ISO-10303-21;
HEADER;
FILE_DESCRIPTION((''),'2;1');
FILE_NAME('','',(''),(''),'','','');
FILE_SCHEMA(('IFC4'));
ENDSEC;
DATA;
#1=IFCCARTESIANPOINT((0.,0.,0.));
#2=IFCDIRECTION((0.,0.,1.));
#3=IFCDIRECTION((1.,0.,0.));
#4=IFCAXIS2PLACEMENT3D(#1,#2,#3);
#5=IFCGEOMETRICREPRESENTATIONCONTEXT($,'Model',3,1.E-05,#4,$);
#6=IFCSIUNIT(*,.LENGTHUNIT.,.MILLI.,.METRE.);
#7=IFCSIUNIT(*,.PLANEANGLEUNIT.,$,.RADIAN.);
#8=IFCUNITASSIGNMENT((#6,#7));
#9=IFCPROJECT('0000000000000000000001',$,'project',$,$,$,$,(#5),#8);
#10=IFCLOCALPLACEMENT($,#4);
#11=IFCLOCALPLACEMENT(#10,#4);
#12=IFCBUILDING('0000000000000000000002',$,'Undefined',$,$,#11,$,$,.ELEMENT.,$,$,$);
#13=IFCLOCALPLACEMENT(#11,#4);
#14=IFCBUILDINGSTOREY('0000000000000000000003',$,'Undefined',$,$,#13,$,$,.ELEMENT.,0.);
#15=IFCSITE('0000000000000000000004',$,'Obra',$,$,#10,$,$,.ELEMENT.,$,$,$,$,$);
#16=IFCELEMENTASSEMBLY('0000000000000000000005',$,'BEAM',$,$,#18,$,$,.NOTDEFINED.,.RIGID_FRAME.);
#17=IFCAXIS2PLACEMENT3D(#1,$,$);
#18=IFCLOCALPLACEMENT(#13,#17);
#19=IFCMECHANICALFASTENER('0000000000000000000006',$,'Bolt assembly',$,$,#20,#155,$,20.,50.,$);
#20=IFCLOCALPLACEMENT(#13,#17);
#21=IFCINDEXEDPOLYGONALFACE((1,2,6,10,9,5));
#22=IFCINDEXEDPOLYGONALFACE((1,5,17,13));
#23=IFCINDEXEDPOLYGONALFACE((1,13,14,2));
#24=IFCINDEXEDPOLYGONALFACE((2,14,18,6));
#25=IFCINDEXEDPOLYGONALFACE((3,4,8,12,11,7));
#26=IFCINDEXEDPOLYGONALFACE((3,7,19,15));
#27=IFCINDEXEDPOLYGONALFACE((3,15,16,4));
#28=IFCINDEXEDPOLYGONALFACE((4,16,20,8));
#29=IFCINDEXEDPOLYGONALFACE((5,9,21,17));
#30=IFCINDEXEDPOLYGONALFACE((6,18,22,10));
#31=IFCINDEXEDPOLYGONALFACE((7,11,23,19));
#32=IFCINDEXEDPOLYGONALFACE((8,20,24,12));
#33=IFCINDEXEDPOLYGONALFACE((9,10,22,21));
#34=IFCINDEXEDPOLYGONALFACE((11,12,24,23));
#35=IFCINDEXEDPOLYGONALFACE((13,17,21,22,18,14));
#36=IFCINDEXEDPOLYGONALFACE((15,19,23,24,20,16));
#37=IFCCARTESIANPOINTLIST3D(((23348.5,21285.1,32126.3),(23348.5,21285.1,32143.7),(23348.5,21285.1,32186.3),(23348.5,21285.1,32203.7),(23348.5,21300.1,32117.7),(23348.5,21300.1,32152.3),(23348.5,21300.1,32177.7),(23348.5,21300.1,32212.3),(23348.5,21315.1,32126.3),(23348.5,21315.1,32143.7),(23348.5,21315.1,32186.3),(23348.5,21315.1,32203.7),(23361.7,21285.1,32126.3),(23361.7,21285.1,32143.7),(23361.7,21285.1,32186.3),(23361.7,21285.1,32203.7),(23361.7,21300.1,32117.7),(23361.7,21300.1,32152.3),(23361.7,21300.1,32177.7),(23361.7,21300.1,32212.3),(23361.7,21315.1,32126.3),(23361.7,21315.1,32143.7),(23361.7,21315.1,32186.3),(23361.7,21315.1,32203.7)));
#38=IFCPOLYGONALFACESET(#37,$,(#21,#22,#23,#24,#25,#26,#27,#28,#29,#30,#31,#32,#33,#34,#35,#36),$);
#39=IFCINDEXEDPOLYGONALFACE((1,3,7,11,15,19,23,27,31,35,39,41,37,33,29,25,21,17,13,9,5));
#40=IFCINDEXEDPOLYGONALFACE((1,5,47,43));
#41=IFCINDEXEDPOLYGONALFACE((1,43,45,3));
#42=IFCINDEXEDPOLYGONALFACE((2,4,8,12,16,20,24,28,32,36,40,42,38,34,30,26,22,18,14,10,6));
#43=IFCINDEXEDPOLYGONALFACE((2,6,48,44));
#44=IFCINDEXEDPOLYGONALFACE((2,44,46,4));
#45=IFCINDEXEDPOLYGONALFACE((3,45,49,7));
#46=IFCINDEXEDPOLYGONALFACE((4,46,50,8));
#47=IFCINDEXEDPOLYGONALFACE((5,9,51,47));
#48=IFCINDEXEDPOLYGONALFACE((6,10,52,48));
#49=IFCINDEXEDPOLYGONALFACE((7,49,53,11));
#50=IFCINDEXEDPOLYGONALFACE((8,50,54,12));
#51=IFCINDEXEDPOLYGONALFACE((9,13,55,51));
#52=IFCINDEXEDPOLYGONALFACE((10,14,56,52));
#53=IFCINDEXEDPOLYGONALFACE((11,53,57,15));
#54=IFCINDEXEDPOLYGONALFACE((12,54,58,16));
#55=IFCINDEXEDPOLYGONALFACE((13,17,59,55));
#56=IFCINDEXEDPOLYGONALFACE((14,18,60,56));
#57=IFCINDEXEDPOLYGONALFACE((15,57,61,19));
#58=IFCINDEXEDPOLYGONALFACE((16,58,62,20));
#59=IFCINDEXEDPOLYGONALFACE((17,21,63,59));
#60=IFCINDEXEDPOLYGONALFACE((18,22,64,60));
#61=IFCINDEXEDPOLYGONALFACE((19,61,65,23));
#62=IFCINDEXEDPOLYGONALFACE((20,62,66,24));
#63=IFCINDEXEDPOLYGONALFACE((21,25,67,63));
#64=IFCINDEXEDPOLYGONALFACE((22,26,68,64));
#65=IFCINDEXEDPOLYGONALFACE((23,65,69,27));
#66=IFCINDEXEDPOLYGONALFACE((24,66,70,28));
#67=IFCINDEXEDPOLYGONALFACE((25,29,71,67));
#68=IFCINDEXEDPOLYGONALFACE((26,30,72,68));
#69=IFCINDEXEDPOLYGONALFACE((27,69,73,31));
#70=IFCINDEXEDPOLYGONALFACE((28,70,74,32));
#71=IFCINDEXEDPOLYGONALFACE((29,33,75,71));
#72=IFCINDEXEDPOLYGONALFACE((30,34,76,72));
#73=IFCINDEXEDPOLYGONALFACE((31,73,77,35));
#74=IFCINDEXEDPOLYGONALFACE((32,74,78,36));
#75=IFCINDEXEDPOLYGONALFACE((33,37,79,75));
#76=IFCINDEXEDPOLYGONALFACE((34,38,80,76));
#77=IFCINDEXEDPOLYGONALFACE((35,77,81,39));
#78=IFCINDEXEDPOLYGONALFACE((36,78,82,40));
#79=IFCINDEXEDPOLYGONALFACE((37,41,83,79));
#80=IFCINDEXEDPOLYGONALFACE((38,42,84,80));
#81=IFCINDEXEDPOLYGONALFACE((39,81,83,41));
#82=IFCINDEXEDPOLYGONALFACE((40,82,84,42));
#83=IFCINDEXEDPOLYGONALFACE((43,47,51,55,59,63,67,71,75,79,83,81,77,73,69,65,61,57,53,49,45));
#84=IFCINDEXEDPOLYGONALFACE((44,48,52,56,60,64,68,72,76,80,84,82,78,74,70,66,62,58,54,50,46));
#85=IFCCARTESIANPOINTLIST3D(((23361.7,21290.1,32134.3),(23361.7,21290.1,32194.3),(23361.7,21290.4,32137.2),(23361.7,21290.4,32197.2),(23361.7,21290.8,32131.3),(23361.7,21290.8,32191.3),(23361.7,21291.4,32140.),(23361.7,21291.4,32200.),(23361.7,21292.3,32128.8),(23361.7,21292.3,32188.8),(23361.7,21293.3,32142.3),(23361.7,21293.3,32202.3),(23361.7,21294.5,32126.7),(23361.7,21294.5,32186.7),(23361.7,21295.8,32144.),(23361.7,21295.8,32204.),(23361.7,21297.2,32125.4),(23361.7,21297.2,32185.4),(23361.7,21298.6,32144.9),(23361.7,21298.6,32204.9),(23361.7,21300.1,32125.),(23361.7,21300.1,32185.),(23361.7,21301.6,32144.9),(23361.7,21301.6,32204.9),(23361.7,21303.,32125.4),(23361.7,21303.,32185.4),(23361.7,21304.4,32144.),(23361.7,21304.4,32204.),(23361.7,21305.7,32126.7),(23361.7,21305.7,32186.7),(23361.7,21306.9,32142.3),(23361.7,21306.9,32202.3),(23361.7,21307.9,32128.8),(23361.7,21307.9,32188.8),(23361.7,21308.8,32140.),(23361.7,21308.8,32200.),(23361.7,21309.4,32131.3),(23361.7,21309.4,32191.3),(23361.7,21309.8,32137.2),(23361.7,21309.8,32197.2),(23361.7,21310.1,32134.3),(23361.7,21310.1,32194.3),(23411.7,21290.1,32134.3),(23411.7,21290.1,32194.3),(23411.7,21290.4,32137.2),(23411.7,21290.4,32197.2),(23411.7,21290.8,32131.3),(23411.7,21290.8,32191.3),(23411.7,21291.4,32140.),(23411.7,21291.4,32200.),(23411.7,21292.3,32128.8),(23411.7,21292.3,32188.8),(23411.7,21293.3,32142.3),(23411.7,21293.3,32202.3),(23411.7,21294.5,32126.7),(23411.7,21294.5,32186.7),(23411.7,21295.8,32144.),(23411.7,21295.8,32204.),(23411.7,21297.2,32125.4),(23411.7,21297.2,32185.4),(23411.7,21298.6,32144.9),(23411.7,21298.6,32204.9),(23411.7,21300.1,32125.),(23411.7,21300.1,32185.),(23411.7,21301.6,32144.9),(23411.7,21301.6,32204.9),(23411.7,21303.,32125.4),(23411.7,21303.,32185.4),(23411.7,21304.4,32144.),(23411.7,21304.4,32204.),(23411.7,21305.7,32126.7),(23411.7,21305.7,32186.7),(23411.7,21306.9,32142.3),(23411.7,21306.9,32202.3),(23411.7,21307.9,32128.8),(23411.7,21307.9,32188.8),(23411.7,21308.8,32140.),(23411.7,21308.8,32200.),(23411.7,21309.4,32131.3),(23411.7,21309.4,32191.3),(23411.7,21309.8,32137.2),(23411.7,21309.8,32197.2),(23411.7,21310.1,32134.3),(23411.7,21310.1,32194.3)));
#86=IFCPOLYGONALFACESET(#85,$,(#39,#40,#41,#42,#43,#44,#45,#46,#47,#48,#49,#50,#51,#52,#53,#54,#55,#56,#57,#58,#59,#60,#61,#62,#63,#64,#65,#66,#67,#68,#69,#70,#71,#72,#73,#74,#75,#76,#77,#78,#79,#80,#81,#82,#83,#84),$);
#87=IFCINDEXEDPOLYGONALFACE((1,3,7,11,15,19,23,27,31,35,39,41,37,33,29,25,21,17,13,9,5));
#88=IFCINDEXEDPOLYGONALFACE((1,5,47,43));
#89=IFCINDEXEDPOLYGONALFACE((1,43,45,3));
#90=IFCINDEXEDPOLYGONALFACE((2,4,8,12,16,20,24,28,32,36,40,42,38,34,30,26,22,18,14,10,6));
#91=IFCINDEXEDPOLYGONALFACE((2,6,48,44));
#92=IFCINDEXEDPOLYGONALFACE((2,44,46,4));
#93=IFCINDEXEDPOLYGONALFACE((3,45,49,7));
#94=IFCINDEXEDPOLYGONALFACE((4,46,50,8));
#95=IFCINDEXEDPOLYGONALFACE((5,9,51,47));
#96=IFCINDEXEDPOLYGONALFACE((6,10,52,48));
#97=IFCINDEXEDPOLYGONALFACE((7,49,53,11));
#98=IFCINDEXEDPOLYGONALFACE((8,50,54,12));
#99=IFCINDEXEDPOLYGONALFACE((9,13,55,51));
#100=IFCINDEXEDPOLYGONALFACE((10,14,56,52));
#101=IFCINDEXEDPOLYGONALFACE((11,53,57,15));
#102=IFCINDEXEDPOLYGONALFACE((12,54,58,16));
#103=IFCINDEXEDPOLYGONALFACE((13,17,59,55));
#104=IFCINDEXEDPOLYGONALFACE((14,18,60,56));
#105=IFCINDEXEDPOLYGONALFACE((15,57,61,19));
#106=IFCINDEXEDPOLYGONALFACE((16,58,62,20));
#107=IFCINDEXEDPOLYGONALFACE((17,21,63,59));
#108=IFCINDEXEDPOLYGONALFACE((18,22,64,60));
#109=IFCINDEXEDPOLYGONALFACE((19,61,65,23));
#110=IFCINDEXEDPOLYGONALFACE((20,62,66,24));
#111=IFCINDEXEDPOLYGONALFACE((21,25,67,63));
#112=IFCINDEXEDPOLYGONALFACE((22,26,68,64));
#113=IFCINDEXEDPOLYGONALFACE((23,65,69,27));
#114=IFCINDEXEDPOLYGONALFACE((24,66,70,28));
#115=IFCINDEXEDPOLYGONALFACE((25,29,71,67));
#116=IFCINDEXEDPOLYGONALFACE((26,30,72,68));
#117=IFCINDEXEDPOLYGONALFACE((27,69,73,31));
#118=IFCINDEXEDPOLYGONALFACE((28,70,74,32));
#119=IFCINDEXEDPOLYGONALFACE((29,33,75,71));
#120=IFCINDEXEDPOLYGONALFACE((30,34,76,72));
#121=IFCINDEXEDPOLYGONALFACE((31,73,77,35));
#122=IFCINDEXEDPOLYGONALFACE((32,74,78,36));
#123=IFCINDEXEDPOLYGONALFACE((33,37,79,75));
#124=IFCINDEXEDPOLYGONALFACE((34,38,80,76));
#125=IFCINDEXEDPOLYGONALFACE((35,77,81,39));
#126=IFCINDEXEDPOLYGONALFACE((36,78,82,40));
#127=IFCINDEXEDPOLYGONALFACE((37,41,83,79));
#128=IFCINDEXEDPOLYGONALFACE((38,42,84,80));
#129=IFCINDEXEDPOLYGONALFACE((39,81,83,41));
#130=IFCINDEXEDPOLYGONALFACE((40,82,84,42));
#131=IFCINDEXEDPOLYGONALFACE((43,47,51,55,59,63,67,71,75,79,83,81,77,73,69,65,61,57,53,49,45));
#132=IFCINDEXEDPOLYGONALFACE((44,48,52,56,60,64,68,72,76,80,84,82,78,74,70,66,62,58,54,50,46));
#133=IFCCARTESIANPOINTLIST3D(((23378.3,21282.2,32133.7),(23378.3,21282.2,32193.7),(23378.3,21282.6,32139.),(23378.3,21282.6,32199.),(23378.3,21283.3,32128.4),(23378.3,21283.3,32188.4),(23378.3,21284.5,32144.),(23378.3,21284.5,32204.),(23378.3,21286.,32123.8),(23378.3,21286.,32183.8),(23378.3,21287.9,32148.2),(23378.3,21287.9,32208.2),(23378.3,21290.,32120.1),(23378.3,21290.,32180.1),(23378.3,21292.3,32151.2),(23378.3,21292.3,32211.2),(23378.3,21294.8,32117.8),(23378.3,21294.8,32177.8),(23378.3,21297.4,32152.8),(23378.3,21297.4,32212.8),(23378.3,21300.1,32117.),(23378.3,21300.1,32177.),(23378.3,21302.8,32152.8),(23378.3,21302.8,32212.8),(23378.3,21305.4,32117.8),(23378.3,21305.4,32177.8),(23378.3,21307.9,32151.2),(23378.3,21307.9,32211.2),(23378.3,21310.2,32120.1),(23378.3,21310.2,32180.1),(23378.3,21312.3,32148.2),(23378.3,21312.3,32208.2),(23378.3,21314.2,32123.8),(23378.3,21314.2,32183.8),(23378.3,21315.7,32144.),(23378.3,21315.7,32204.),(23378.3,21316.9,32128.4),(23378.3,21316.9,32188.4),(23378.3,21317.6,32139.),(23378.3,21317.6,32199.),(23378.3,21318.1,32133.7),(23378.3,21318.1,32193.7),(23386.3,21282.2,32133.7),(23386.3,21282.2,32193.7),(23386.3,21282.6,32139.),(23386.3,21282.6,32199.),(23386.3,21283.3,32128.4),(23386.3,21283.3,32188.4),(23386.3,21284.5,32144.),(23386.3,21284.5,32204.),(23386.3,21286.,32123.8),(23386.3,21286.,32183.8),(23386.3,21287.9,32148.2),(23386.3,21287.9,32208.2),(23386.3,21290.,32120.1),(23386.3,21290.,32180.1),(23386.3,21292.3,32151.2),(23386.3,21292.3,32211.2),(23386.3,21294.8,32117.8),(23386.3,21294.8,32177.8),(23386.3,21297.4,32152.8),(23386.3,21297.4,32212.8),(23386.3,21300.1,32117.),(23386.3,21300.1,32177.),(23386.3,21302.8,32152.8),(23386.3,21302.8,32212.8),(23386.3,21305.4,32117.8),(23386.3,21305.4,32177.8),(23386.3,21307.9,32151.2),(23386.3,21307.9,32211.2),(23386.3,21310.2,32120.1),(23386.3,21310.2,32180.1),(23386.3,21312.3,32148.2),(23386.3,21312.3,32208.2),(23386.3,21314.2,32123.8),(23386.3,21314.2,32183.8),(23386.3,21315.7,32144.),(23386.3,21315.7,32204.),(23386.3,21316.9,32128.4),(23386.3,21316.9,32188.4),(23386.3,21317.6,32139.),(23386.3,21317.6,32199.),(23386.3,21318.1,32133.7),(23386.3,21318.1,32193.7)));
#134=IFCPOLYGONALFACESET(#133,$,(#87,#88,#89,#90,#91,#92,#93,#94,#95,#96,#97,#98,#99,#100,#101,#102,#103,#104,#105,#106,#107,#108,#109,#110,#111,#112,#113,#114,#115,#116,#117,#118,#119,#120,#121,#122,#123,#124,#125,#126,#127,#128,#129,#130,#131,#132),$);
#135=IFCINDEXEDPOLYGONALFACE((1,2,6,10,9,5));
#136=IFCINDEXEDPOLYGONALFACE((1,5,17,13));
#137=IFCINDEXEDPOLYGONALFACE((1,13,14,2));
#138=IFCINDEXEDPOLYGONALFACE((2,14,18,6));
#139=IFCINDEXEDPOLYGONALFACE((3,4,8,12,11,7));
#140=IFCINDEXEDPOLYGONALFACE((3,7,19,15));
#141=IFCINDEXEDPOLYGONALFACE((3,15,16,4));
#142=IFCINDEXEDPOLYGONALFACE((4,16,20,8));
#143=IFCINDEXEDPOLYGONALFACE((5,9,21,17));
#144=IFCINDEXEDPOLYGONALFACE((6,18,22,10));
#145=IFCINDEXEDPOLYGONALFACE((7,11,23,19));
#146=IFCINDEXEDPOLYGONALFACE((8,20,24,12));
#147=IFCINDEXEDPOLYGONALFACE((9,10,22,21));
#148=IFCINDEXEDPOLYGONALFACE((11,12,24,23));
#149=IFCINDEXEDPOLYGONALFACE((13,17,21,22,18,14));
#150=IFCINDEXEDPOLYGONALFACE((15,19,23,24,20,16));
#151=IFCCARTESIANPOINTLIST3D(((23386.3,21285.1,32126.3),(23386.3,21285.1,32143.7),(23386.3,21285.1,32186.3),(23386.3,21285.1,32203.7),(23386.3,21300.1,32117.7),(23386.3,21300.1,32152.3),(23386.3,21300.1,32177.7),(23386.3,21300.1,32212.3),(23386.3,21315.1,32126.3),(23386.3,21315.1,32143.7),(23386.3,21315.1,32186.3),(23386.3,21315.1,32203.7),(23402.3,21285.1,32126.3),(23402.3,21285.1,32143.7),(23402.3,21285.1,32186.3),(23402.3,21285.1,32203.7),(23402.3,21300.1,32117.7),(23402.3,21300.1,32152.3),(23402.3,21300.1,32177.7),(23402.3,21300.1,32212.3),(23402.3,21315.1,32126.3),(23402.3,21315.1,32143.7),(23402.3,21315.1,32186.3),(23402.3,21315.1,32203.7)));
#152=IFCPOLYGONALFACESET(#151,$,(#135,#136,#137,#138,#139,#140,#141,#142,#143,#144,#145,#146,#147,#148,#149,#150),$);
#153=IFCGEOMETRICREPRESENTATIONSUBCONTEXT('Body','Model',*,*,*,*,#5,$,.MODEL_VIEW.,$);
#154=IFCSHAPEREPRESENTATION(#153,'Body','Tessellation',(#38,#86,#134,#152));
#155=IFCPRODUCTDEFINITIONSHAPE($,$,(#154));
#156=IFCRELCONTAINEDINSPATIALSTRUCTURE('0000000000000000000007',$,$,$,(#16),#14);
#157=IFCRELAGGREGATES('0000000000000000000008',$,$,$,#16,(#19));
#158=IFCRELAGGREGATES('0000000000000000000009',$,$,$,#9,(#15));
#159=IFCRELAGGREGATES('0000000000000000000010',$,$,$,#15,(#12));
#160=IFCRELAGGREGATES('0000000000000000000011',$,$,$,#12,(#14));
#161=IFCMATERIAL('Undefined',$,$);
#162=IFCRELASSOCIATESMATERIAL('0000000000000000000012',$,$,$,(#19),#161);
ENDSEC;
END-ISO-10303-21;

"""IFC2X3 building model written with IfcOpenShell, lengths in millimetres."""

from ifc_helpers import new_model, si_unit, frame, origin_with_axes, origin_2d_with_axis, place, context, subcontext, project, spatial, polyline, circle, outline, extrude, source, transform, mapped, material, element, aggregate, save


model = new_model("IFC2X3")

# Units and contexts
model_context = context("Model", 3, precision=1e-05, world=origin_with_axes())
body_context = subcontext(model_context, "Body", "Model", "MODEL_VIEW")
ifc_project = project(units=[si_unit("LENGTHUNIT", "METRE", prefix="MILLI"), si_unit("PLANEANGLEUNIT", "RADIAN")], contexts=[model_context])

# Site, building, storey
site_placement = place(None, origin_with_axes())
site = spatial("IfcSite", under=ifc_project, at=site_placement, Name="Obra", CompositionType="ELEMENT")
building_placement = place(site_placement, origin_with_axes())
building = spatial("IfcBuilding", under=site, at=building_placement, Name="Undefined", CompositionType="ELEMENT")
storey_placement = place(building_placement, origin_with_axes())
storey = spatial("IfcBuildingStorey", under=building, at=storey_placement, Name="Undefined", CompositionType="ELEMENT", Elevation=0.0)

# Shared definitions
ifc_material_1 = material(Name="Undefined")

# Element assembly, mechanical fastener
shared_shape_1 = source(origin_with_axes(), body_context, "Body", "SweptSolid", [
    extrude(outline(polyline([(17.3, 0.0), (8.7, 15.0), (-8.7, 15.0), (-17.3, 0.0), (-8.7, -15.0), (8.7, -15.0), (17.3, 0.0)])), frame((0.0, -26.5, 0.0), z_axis=(0.0, 1.0, 0.0), x_axis=(1.0, 0.0, 0.0)), (0.0, 0.0, 1.0), 13.2),
    extrude(circle(Radius=10.0, at=origin_2d_with_axis()), frame((0.0, -13.3, 0.0), z_axis=(0.0, 1.0, 0.0), x_axis=(1.0, 0.0, 0.0)), (0.0, 0.0, 1.0), 50.0),
    extrude(circle(Radius=18.0, at=origin_2d_with_axis()), frame((0.0, 3.3, 0.0), z_axis=(0.0, 1.0, 0.0), x_axis=(1.0, 0.0, 0.0)), (0.0, 0.0, 1.0), 8.0),
    extrude(outline(polyline([(17.3, 0.0), (8.7, 15.0), (-8.7, 15.0), (-17.3, 0.0), (-8.7, -15.0), (8.7, -15.0), (17.3, 0.0)])), frame((0.0, 11.3, 0.0), z_axis=(0.0, 1.0, 0.0), x_axis=(1.0, 0.0, 0.0)), (0.0, 0.0, 1.0), 16.0),
])
assembly_1_placement = place(storey_placement, origin_with_axes())
assembly_1 = element("IfcElementAssembly", 1, at=assembly_1_placement, inside=storey, Name="BEAM", AssemblyPlace="NOTDEFINED", PredefinedType="RIGID_FRAME")
mechanical_fastener_1_placement = place(assembly_1_placement, frame((23375.0, 21340.1, 32235.0), z_axis=(0.0, -1.0, 0.0), x_axis=(0.0, 0.0, -1.0)))
mechanical_fastener_1 = element("IfcMechanicalFastener", 2, at=mechanical_fastener_1_placement, material=ifc_material_1, Name="Bolt assembly", NominalDiameter=20.0, NominalLength=50.0, context=body_context, shape_type="MappedRepresentation", body=[
    mapped(shared_shape_1, transform((40.0, 0.0, 40.0))),
    mapped(shared_shape_1, transform((100.0, 0.0, 40.0))),
])
aggregate(assembly_1, [mechanical_fastener_1])

save(model, "model.ifc")
